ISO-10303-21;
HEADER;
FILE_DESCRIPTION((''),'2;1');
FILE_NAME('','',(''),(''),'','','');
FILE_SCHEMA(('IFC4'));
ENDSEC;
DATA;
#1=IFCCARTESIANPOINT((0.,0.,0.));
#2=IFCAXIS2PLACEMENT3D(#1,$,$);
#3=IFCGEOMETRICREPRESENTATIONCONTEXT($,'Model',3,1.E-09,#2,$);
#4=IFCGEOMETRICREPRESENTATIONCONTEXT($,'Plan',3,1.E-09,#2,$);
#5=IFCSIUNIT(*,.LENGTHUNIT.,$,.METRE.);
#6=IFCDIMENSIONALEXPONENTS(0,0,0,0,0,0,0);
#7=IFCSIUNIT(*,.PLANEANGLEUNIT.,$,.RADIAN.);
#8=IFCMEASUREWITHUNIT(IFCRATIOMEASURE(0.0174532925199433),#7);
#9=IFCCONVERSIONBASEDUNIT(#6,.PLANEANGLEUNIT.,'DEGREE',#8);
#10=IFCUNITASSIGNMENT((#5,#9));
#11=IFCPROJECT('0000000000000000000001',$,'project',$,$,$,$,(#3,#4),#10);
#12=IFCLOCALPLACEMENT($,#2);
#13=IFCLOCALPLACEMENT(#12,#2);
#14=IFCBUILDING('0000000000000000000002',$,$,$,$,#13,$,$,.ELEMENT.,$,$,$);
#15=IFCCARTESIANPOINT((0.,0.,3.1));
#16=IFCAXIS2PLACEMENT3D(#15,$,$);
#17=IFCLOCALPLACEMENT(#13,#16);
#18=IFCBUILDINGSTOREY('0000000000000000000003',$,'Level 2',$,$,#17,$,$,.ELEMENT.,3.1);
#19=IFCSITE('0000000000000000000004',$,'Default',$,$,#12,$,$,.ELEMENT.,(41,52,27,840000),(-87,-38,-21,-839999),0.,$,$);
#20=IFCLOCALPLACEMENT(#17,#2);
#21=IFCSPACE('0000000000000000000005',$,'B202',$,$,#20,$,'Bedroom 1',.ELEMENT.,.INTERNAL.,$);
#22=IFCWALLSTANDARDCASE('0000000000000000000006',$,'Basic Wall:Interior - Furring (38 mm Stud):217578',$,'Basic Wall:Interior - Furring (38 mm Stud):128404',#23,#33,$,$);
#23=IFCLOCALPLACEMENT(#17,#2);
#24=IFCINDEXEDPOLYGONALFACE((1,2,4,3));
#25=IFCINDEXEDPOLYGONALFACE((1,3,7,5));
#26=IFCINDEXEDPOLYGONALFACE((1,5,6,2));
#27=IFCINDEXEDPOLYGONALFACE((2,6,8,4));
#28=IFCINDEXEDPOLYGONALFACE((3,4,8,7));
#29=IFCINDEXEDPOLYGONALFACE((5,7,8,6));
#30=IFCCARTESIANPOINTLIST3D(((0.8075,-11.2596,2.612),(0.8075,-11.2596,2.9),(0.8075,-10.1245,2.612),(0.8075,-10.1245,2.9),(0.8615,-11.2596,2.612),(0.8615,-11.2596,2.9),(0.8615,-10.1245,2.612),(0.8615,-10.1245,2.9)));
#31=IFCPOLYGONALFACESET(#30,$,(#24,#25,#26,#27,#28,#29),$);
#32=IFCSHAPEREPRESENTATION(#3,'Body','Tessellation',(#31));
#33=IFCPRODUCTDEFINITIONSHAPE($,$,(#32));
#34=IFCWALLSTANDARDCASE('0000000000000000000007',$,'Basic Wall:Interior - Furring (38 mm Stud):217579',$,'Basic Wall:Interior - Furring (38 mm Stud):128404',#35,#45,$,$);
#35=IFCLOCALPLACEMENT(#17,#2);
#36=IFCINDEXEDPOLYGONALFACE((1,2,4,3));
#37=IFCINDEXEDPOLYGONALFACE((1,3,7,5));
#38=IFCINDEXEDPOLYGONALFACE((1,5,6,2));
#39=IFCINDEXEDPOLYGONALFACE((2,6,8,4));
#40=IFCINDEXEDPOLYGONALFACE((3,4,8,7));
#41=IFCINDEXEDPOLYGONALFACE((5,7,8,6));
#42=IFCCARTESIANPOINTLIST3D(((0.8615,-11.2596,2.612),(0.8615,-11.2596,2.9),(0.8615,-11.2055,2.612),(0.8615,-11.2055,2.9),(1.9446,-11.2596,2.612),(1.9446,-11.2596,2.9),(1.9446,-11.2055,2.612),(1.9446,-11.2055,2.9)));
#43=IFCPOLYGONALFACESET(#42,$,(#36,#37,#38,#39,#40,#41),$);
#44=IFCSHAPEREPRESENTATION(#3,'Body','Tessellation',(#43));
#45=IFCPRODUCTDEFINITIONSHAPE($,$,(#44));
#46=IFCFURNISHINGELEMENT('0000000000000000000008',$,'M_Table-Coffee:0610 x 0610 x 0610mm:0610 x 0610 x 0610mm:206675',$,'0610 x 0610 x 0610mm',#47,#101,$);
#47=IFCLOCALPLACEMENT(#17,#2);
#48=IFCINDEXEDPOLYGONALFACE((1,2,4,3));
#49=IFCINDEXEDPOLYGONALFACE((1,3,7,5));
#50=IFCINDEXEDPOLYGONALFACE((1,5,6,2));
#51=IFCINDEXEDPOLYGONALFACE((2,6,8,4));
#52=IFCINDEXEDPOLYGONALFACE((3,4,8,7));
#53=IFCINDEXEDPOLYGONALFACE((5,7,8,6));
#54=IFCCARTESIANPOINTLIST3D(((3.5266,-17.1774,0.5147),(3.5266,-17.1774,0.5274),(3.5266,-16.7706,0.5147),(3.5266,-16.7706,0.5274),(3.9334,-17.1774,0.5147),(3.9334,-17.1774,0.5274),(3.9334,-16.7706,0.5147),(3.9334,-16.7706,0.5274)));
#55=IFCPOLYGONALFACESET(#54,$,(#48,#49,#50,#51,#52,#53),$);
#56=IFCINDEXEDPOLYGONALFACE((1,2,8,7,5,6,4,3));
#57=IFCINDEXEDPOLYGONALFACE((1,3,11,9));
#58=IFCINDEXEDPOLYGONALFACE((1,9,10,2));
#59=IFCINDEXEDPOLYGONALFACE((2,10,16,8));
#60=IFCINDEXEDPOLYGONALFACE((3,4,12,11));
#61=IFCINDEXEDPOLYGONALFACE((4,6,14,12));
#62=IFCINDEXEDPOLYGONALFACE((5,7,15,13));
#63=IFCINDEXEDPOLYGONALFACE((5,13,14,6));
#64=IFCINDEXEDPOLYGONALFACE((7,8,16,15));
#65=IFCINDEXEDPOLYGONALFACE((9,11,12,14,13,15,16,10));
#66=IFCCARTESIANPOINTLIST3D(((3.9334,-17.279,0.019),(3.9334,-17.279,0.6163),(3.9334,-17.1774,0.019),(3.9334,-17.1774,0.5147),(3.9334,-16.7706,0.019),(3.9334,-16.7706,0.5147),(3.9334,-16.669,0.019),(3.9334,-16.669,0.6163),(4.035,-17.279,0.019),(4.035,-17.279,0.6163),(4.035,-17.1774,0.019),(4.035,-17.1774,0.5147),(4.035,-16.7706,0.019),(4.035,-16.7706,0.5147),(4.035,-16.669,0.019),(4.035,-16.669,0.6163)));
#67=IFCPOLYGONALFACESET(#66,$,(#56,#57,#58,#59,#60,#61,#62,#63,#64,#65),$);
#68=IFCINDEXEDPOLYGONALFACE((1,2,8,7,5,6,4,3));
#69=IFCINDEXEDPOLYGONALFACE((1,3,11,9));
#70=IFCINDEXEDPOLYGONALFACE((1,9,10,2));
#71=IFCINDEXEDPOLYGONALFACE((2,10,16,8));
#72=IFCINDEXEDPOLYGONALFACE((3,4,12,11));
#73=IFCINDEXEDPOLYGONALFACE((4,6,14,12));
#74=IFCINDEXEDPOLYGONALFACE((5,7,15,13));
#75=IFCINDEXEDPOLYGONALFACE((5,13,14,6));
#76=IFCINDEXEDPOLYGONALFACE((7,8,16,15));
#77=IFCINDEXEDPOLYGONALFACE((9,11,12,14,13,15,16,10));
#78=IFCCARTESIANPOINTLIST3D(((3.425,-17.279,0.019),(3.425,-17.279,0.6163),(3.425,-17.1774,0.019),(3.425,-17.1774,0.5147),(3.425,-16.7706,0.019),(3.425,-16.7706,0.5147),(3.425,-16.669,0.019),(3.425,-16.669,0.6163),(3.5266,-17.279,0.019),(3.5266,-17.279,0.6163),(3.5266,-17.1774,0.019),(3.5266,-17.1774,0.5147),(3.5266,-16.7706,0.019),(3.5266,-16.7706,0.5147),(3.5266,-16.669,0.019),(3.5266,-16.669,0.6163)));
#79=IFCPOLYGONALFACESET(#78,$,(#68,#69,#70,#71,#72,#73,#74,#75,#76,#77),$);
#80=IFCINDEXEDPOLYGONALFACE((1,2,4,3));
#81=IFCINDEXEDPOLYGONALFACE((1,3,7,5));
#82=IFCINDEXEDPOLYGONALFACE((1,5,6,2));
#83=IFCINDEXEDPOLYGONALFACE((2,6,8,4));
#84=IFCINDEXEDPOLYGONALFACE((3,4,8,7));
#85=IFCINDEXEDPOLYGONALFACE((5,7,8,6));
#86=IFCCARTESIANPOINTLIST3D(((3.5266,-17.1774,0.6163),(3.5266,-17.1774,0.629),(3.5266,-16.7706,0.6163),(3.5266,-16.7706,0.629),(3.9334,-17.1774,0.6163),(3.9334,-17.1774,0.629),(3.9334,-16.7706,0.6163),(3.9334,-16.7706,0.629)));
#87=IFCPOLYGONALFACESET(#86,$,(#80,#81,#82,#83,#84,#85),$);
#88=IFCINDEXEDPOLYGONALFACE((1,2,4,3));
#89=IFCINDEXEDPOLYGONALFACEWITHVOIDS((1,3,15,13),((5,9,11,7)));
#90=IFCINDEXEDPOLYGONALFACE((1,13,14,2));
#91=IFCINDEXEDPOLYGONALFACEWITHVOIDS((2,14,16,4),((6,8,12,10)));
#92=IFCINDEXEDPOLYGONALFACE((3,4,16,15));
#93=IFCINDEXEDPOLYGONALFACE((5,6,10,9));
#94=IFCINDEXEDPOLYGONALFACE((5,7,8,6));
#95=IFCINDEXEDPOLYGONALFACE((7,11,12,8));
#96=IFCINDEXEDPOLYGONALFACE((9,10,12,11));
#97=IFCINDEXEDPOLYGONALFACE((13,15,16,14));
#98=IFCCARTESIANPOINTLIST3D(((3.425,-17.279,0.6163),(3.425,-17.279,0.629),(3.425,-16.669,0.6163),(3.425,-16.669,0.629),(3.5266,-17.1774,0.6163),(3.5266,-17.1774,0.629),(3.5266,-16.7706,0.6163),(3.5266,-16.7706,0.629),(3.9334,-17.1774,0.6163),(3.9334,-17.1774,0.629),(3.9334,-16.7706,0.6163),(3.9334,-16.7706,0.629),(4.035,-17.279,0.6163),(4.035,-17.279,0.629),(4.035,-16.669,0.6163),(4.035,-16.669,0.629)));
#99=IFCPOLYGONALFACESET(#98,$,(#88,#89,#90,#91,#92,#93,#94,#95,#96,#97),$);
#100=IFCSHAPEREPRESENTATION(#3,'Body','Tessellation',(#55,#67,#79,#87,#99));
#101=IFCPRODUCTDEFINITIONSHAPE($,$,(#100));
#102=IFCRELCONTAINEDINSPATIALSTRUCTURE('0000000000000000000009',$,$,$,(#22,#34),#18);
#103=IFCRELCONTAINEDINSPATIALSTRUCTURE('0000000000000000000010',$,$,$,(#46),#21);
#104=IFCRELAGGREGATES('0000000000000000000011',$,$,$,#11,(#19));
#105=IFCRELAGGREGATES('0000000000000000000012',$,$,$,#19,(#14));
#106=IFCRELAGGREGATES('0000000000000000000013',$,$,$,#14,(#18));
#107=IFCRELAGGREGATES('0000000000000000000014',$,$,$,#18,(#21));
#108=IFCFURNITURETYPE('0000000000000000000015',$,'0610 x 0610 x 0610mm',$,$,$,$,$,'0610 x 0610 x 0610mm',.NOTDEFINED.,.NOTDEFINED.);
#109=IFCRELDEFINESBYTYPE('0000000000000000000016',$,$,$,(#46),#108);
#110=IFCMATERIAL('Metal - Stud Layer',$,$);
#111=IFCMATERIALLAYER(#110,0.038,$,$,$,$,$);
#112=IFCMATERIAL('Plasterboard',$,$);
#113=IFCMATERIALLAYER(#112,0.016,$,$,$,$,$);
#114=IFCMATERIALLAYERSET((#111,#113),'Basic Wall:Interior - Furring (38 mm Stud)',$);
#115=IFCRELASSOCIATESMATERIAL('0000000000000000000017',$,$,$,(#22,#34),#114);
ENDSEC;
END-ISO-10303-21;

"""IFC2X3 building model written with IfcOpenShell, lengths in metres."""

from ifc_helpers import new_model, entity, si_unit, converted_unit, frame, frame_2d, origin, origin_2d_with_axis, place, context, project, spatial, polyline, rectangle, outline, extrude, source, transform, mapped, material, layer, layer_set, layer_usage, type_object, type_shapes, element, save


model = new_model("IFC2X3")

# Units and contexts
model_context = context("Model", 3, precision=1e-09, world=origin())
plan_context = context("Plan", 3, precision=1e-09, world=origin())
ifc_project = project(units=[si_unit("LENGTHUNIT", "METRE"), converted_unit("PLANEANGLEUNIT", "DEGREE", entity("IfcRatioMeasure", 0.0174532925199433), si_unit("PLANEANGLEUNIT", "RADIAN"), dimensions=[0, 0, 0, 0, 0, 0, 0])], contexts=[model_context, plan_context])

# Site, building, storey
site_placement = place(None, origin())
site = spatial("IfcSite", under=ifc_project, at=site_placement, Name="Default", CompositionType="ELEMENT", RefLatitude=(41, 52, 27, 840000), RefLongitude=(-87, -38, -21, -839999), RefElevation=0.0)
building_placement = place(site_placement, origin())
building = spatial("IfcBuilding", under=site, at=building_placement, CompositionType="ELEMENT")
storey_placement = place(building_placement, frame((0.0, 0.0, 3.1)))
storey = spatial("IfcBuildingStorey", under=building, at=storey_placement, Name="Level 2", CompositionType="ELEMENT", Elevation=3.1)

# Shared definitions
ifc_material_1 = material(Name="Metal - Stud Layer")
ifc_material_2 = material(Name="Plasterboard")

# Walls
ifc_layer_1 = layer(ifc_material_1, 0.038)
ifc_layer_2 = layer(ifc_material_2, 0.016)
ifc_layer_set_1 = layer_set([ifc_layer_1, ifc_layer_2], Name="Basic Wall:Interior - Furring (38 mm Stud)")
ifc_layer_usage_1 = layer_usage(ifc_layer_set_1, "AXIS2", "NEGATIVE", 0.027)
wall_1_placement = place(storey_placement, frame((0.8345, -11.2596, 2.612), z_axis=(0.0, 0.0, 1.0), x_axis=(0.0, 1.0, 0.0)))
element("IfcWallStandardCase", 1, at=wall_1_placement, inside=storey, material=ifc_layer_usage_1, Name="Basic Wall:Interior - Furring (38 mm Stud):217578", ObjectType="Basic Wall:Interior - Furring (38 mm Stud):128404", context=model_context, shape_type="SweptSolid", body=[
    extrude(rectangle(XDim=1.1351, YDim=0.054, at=frame_2d((0.5675, 0.0), x_axis=(-1.0, 0.0))), origin(), (0.0, 0.0, 1.0), 0.288),
])
ifc_layer_usage_2 = layer_usage(ifc_layer_set_1, "AXIS2", "NEGATIVE", 0.027)
wall_2_placement = place(storey_placement, frame((1.9446, -11.2325, 2.612), z_axis=(0.0, 0.0, 1.0), x_axis=(-1.0, 0.0, 0.0)))
element("IfcWallStandardCase", 2, at=wall_2_placement, inside=storey, material=ifc_layer_usage_2, Name="Basic Wall:Interior - Furring (38 mm Stud):217579", ObjectType="Basic Wall:Interior - Furring (38 mm Stud):128404", context=model_context, shape_type="SweptSolid", body=[
    extrude(rectangle(XDim=1.0831, YDim=0.054, at=frame_2d((0.5415, 0.0), x_axis=(-1.0, 0.0))), origin(), (0.0, 0.0, 1.0), 0.288),
])

# Shared definitions
space_placement = place(storey_placement, origin())
space = spatial("IfcSpace", under=storey, at=space_placement, Name="B202", LongName="Bedroom 1", CompositionType="ELEMENT", InteriorOrExteriorSpace="INTERNAL")

# Furnishing element
furniture_type = type_object("IfcFurnitureType", Name="0610 x 0610 x 0610mm", ElementType="0610 x 0610 x 0610mm", AssemblyPlace="NOTDEFINED")
shared_shape_1 = source(origin(), model_context, "Body", "SweptSolid", [
    extrude(rectangle(XDim=0.4068, YDim=0.4068, at=origin_2d_with_axis()), frame((0.0183, 0.0952, 0.4957), z_axis=(0.0, 0.0, 1.0), x_axis=(-1.0, 0.0, 0.0)), (0.0, 0.0, 1.0), 0.0127),
    extrude(outline(polyline([(-0.2732, -0.305), (0.324, -0.305), (0.324, 0.305), (-0.2732, 0.305), (-0.2732, 0.2034), (0.2225, 0.2034), (0.2225, -0.2034), (-0.2732, -0.2034), (-0.2732, -0.305)])), frame((0.2217, 0.0952, 0.2732), z_axis=(1.0, 0.0, 0.0), x_axis=(0.0, 0.0, 1.0)), (0.0, 0.0, 1.0), 0.1016),
    extrude(outline(polyline([(-0.305, -0.3241), (0.305, -0.3241), (0.305, 0.2733), (0.2034, 0.2733), (0.2034, -0.2224), (-0.2034, -0.2224), (-0.2034, 0.2733), (-0.305, 0.2733), (-0.305, -0.3241)])), frame((-0.2867, 0.0952, 0.2733), z_axis=(1.0, 0.0, 0.0), x_axis=(0.0, -1.0, 0.0)), (0.0, 0.0, 1.0), 0.1016),
    extrude(rectangle(XDim=0.4068, YDim=0.4068, at=origin_2d_with_axis()), frame((0.0183, 0.0952, 0.5973), z_axis=(0.0, 0.0, 1.0), x_axis=(-1.0, 0.0, 0.0)), (0.0, 0.0, 1.0), 0.0127),
    extrude(outline(polyline([(-0.305, -0.305), (0.305, -0.305), (0.305, 0.305), (-0.305, 0.305), (-0.305, -0.305)]), holes=[polyline([(-0.2034, -0.2034), (-0.2034, 0.2034), (0.2034, 0.2034), (0.2034, -0.2034), (-0.2034, -0.2034)])]), frame((0.0183, 0.0952, 0.5973), z_axis=(0.0, 0.0, 1.0), x_axis=(-1.0, 0.0, 0.0)), (0.0, 0.0, 1.0), 0.0127),
])
type_shapes(furniture_type, [shared_shape_1])
furnishing_placement = place(space_placement, frame((3.7117, -17.0692, 0.019)))
element("IfcFurnishingElement", 3, at=furnishing_placement, inside=space, type_object=furniture_type, Name="M_Table-Coffee:0610 x 0610 x 0610mm:0610 x 0610 x 0610mm:206675", ObjectType="0610 x 0610 x 0610mm", context=model_context, shape_type="MappedRepresentation", body=[
    mapped(shared_shape_1, transform((0.0, 0.0, 0.0), scale=1.0)),
])

save(model, "model.ifc")
